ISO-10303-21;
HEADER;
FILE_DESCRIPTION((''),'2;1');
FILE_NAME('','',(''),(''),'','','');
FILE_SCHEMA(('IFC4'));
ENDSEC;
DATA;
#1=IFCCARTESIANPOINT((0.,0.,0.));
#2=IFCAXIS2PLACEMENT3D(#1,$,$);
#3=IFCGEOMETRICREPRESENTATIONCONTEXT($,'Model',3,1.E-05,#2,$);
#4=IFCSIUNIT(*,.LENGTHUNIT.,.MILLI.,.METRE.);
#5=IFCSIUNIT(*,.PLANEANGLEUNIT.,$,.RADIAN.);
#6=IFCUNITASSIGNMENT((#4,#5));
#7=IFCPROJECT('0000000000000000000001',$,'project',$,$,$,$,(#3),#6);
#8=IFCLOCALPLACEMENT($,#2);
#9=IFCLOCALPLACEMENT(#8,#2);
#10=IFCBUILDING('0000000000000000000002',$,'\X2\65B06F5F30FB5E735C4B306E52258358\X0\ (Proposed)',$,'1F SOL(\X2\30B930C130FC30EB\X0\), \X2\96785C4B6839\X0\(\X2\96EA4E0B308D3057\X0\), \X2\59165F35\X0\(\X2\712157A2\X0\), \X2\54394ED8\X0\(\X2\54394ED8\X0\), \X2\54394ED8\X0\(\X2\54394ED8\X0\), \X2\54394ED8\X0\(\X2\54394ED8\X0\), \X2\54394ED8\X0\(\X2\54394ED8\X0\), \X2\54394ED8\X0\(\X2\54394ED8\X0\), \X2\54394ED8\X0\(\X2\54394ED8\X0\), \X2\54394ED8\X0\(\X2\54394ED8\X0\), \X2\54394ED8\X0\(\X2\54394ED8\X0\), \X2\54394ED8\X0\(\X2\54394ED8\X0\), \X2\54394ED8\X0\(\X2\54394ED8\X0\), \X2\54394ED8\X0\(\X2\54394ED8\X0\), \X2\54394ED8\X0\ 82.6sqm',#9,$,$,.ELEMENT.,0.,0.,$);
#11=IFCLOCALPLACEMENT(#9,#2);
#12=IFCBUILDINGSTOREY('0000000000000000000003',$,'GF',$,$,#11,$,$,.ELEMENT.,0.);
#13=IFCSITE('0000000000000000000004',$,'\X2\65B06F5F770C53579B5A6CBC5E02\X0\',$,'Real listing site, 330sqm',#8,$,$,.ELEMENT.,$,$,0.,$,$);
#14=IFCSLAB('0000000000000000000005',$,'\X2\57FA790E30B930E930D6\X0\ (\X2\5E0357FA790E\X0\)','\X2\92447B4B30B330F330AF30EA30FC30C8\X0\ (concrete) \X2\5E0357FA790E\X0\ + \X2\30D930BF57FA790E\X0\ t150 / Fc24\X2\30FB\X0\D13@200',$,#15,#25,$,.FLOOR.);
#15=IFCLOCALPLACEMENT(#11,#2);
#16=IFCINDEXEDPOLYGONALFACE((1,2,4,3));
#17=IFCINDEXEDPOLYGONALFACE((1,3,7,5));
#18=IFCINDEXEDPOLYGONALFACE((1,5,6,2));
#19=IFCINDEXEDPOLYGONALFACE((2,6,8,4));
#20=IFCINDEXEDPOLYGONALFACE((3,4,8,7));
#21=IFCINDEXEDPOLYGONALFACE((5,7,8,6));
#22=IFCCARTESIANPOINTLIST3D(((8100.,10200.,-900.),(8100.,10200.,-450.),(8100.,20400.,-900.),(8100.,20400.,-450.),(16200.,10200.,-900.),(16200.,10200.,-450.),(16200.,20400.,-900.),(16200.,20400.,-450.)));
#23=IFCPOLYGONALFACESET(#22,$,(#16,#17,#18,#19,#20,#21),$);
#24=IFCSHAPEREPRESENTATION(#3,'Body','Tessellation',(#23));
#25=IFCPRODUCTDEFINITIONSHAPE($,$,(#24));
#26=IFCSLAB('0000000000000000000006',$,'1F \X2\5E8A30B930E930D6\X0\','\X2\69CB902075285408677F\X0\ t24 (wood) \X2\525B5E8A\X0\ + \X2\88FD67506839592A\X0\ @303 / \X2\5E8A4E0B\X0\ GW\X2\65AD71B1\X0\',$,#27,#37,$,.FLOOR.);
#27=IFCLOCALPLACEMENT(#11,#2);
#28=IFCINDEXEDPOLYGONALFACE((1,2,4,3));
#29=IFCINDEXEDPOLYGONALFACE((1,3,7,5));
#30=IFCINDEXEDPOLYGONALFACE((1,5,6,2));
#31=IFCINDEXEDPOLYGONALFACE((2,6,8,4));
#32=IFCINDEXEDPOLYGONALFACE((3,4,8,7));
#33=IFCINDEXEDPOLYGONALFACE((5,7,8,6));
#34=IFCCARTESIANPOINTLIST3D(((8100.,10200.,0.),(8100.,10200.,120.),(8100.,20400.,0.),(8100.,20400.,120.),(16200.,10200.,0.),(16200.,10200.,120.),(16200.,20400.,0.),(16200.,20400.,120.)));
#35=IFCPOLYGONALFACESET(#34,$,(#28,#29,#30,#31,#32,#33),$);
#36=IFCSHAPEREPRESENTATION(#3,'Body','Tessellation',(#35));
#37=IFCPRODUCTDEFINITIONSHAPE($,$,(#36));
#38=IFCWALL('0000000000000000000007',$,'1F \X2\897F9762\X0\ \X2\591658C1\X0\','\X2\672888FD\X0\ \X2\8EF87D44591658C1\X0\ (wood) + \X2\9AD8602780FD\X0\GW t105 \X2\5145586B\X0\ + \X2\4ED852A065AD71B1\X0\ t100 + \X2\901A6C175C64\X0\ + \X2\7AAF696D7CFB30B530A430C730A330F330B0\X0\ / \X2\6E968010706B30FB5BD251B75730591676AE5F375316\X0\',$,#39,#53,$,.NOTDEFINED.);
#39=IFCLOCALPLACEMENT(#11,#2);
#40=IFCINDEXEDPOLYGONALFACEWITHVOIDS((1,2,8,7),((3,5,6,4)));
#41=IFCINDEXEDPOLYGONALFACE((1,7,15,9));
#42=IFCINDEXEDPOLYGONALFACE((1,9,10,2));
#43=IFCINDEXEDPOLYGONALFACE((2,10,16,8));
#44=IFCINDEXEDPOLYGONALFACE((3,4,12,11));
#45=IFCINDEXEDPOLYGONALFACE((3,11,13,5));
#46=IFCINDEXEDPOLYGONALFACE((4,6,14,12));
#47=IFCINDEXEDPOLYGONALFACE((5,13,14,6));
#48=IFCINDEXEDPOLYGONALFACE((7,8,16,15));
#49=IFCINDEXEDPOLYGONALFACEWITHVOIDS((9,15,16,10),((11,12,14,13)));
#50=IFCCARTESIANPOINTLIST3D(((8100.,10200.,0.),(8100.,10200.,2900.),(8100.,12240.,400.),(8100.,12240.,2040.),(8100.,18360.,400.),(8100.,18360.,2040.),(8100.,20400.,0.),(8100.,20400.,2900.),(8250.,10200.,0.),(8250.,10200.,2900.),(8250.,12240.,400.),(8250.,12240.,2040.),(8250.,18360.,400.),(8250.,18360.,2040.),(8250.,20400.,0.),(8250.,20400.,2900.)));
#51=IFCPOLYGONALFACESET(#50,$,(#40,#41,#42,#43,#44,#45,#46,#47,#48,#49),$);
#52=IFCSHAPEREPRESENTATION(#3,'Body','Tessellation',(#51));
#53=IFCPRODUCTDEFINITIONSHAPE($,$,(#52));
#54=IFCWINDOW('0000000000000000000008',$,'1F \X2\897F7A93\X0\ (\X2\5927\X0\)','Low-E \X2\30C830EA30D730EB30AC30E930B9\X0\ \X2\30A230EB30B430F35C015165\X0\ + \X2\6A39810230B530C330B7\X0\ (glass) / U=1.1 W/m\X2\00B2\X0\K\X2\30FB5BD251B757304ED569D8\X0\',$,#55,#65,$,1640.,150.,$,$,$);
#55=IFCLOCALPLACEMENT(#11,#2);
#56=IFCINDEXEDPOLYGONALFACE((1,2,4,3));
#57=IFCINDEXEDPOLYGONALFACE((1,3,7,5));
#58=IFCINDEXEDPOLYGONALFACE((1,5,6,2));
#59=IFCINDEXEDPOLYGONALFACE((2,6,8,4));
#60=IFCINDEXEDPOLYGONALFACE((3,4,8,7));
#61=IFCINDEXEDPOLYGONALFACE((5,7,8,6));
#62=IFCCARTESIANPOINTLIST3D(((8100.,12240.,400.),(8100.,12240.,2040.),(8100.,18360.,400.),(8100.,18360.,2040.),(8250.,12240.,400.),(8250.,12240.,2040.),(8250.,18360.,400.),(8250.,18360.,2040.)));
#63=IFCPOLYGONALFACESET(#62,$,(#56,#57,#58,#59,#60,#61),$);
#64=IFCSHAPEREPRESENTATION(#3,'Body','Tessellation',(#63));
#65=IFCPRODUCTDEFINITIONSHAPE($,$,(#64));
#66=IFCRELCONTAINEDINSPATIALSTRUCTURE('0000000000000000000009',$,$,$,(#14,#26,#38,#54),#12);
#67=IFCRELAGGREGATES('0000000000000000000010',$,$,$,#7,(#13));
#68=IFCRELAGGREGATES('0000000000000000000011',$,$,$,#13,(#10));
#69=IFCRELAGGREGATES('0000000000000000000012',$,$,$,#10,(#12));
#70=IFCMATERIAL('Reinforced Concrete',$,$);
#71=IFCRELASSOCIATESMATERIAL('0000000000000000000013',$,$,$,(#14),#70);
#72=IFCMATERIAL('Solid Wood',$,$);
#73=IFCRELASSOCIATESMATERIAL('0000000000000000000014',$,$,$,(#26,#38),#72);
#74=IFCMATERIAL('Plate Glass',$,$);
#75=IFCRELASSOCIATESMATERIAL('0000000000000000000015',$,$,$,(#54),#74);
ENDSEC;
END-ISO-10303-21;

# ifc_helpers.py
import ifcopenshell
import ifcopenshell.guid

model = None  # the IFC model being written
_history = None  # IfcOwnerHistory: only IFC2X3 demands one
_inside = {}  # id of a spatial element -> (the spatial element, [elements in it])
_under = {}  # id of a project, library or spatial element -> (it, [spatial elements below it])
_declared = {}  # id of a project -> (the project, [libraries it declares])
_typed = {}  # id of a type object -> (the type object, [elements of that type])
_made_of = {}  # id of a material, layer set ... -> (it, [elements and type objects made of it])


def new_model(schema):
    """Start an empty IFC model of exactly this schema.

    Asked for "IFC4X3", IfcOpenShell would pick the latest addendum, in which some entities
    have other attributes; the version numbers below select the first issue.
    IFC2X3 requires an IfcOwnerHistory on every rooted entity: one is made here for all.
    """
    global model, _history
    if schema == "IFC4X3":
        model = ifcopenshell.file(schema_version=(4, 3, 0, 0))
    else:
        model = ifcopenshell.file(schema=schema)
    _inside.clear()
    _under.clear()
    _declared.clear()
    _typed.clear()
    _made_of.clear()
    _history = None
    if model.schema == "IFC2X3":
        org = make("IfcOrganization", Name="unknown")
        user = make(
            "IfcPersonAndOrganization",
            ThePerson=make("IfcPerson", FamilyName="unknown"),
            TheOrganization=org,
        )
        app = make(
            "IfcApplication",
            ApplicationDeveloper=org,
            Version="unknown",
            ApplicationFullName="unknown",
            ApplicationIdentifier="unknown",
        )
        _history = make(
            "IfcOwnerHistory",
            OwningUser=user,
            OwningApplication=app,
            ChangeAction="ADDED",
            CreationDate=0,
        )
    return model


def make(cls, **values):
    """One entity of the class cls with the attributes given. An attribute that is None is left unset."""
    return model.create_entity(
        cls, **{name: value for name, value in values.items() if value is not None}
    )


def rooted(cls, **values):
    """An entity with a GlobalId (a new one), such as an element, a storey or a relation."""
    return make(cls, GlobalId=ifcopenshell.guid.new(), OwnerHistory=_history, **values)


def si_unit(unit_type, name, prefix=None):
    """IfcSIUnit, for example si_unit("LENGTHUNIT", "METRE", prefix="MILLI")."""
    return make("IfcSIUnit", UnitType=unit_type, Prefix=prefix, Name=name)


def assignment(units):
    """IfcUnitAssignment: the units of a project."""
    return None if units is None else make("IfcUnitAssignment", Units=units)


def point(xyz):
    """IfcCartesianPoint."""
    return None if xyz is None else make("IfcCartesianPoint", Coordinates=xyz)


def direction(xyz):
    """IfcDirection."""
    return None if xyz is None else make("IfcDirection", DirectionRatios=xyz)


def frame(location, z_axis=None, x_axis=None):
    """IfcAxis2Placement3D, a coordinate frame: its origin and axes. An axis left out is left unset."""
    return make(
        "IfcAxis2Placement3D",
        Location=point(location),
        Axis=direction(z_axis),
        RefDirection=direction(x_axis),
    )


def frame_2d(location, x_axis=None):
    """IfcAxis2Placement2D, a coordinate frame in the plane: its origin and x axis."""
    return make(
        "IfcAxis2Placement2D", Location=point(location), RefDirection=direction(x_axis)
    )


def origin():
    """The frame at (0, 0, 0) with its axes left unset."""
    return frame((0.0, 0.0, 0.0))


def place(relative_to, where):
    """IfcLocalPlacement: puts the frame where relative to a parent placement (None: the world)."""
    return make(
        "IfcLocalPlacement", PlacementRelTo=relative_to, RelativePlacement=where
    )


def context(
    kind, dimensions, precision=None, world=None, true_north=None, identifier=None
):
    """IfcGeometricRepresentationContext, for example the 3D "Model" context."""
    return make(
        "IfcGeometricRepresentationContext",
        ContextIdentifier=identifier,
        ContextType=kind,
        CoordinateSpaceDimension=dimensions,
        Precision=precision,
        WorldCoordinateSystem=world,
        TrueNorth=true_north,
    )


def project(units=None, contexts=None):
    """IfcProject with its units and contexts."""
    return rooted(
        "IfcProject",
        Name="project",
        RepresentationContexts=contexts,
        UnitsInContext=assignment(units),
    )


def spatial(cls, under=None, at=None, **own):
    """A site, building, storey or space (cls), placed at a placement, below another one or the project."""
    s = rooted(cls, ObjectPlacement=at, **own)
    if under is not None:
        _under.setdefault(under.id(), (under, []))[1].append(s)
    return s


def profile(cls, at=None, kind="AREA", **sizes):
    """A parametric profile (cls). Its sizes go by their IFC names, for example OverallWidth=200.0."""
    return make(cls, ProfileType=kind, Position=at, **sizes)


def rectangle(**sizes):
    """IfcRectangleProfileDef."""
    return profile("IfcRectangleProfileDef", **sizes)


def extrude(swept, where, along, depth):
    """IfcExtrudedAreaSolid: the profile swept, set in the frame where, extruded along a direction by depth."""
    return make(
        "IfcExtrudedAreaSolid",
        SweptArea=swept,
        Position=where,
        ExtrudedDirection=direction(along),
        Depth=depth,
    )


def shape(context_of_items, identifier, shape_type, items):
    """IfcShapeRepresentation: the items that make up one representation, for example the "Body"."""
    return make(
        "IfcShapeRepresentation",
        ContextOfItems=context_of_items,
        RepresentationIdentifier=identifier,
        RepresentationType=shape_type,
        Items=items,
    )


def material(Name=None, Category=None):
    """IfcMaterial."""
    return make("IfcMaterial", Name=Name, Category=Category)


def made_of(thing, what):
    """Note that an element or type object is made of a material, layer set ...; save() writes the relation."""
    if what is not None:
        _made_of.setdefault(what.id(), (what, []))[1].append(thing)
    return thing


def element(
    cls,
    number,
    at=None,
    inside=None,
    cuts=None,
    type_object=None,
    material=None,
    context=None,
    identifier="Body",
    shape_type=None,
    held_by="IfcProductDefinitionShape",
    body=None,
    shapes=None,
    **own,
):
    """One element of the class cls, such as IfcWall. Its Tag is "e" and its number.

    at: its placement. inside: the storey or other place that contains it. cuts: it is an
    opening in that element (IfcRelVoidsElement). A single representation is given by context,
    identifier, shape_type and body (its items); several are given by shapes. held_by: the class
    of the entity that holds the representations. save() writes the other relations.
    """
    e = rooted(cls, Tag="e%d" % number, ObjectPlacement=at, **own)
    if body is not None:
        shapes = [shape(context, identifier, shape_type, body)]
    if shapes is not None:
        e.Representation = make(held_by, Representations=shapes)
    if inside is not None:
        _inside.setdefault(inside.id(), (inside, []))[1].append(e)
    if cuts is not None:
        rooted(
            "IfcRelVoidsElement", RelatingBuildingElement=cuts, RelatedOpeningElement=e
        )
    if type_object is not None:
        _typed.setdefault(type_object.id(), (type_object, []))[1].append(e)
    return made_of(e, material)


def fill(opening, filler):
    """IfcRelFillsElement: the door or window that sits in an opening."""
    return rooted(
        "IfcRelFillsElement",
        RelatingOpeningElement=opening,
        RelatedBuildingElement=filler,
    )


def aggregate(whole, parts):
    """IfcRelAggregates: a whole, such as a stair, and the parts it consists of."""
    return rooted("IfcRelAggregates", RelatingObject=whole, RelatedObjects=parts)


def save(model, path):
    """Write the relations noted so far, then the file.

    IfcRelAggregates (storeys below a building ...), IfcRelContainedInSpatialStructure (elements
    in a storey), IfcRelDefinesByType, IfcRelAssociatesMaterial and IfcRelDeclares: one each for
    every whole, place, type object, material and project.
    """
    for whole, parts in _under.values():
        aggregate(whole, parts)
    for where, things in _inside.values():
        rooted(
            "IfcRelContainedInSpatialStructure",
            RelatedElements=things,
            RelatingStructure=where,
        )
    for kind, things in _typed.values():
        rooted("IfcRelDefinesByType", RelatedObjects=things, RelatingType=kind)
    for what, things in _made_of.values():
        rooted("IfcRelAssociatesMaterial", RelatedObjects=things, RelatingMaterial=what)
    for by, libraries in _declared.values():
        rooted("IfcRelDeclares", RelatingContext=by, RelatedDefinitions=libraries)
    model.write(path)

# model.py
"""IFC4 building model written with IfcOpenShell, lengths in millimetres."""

from ifc_helpers import new_model, si_unit, frame, frame_2d, origin, place, context, project, spatial, rectangle, extrude, material, element, fill, save


model = new_model("IFC4")

# Units and contexts
model_context = context("Model", 3, precision=1e-05, world=origin())
ifc_project = project(units=[si_unit("LENGTHUNIT", "METRE", prefix="MILLI"), si_unit("PLANEANGLEUNIT", "RADIAN")], contexts=[model_context])

# Site, building, storey
site_placement = place(None, origin())
site = spatial("IfcSite", under=ifc_project, at=site_placement, Name="新潟県南魚沼市", ObjectType="Real listing site, 330sqm", CompositionType="ELEMENT", RefElevation=0.0)
building_placement = place(site_placement, origin())
building = spatial("IfcBuilding", under=site, at=building_placement, Name="新潟・平屋の別荘 (Proposed)", ObjectType="1F SOL(スチール), 陸屋根(雪下ろし), 外張(無垢), 吹付(吹付), 吹付(吹付), 吹付(吹付), 吹付(吹付), 吹付(吹付), 吹付(吹付), 吹付(吹付), 吹付(吹付), 吹付(吹付), 吹付(吹付), 吹付(吹付), 吹付 82.6sqm", CompositionType="ELEMENT", ElevationOfRefHeight=0.0, ElevationOfTerrain=0.0)
storey_placement = place(building_placement, origin())
storey = spatial("IfcBuildingStorey", under=building, at=storey_placement, Name="GF", CompositionType="ELEMENT", Elevation=0.0)

# Shared definitions
ifc_material_1 = material(Name="Solid Wood")

# Slabs
ifc_material_2 = material(Name="Reinforced Concrete")
slab_1_placement = place(storey_placement, frame((4050.0, 5100.0, -450.0)))
element("IfcSlab", 1, at=slab_1_placement, inside=storey, material=ifc_material_2, Name="基礎スラブ (布基礎)", Description="鉄筋コンクリート (concrete) 布基礎 + ベタ基礎 t150 / Fc24・D13@200", PredefinedType="FLOOR", context=model_context, shape_type="SweptSolid", body=[
    extrude(rectangle(XDim=8100.0, YDim=10200.0, at=frame_2d((4050.0, 5100.0))), frame((4050.0, 5100.0, -450.0)), (0.0, 0.0, 1.0), 450.0),
])
slab_2_placement = place(storey_placement, frame((4050.0, 5100.0, 0.0)))
element("IfcSlab", 2, at=slab_2_placement, inside=storey, material=ifc_material_1, Name="1F 床スラブ", Description="構造用合板 t24 (wood) 剛床 + 製材根太 @303 / 床下 GW断熱", PredefinedType="FLOOR", context=model_context, shape_type="SweptSolid", body=[
    extrude(rectangle(XDim=8100.0, YDim=10200.0, at=frame_2d((4050.0, 5100.0))), frame((4050.0, 5100.0, 0.0)), (0.0, 0.0, 1.0), 120.0),
])

# Shared definitions
ifc_material_3 = material(Name="Plate Glass")

# Wall, opening, window
wall_1_placement = place(storey_placement, frame((4050.0, 5100.0, 0.0)))
wall_1 = element("IfcWall", 3, at=wall_1_placement, inside=storey, material=ifc_material_1, Name="1F 西面 外壁", Description="木製 軸組外壁 (wood) + 高性能GW t105 充填 + 付加断熱 t100 + 通気層 + 窯業系サイディング / 準耐火・寒冷地外皮強化", PredefinedType="NOTDEFINED", context=model_context, shape_type="SweptSolid", body=[
    extrude(rectangle(XDim=150.0, YDim=10200.0, at=frame_2d((75.0, 5100.0))), frame((4050.0, 5100.0, 0.0)), (0.0, 0.0, 1.0), 2900.0),
])
opening_1_placement = place(storey_placement, frame((4050.0, 6120.0, 200.0)))
opening_1 = element("IfcOpeningElement", 4, at=opening_1_placement, cuts=wall_1, PredefinedType="NOTDEFINED", context=model_context, shape_type="SweptSolid", body=[
    extrude(rectangle(XDim=150.0, YDim=6120.0, at=frame_2d((75.0, 3060.0))), frame((4050.0, 6120.0, 200.0)), (0.0, 0.0, 1.0), 1640.0),
])
window_1_placement = place(storey_placement, frame((4050.0, 6120.0, 200.0)))
window_1 = element("IfcWindow", 5, at=window_1_placement, inside=storey, material=ifc_material_3, Name="1F 西窓 (大)", Description="Low-E トリプルガラス アルゴン封入 + 樹脂サッシ (glass) / U=1.1 W/m²K・寒冷地仕様", OverallHeight=1640.0, OverallWidth=150.0, context=model_context, shape_type="SweptSolid", body=[
    extrude(rectangle(XDim=150.0, YDim=6120.0, at=frame_2d((75.0, 3060.0))), frame((4050.0, 6120.0, 200.0)), (0.0, 0.0, 1.0), 1640.0),
])
fill(opening_1, window_1)

save(model, "model.ifc")
